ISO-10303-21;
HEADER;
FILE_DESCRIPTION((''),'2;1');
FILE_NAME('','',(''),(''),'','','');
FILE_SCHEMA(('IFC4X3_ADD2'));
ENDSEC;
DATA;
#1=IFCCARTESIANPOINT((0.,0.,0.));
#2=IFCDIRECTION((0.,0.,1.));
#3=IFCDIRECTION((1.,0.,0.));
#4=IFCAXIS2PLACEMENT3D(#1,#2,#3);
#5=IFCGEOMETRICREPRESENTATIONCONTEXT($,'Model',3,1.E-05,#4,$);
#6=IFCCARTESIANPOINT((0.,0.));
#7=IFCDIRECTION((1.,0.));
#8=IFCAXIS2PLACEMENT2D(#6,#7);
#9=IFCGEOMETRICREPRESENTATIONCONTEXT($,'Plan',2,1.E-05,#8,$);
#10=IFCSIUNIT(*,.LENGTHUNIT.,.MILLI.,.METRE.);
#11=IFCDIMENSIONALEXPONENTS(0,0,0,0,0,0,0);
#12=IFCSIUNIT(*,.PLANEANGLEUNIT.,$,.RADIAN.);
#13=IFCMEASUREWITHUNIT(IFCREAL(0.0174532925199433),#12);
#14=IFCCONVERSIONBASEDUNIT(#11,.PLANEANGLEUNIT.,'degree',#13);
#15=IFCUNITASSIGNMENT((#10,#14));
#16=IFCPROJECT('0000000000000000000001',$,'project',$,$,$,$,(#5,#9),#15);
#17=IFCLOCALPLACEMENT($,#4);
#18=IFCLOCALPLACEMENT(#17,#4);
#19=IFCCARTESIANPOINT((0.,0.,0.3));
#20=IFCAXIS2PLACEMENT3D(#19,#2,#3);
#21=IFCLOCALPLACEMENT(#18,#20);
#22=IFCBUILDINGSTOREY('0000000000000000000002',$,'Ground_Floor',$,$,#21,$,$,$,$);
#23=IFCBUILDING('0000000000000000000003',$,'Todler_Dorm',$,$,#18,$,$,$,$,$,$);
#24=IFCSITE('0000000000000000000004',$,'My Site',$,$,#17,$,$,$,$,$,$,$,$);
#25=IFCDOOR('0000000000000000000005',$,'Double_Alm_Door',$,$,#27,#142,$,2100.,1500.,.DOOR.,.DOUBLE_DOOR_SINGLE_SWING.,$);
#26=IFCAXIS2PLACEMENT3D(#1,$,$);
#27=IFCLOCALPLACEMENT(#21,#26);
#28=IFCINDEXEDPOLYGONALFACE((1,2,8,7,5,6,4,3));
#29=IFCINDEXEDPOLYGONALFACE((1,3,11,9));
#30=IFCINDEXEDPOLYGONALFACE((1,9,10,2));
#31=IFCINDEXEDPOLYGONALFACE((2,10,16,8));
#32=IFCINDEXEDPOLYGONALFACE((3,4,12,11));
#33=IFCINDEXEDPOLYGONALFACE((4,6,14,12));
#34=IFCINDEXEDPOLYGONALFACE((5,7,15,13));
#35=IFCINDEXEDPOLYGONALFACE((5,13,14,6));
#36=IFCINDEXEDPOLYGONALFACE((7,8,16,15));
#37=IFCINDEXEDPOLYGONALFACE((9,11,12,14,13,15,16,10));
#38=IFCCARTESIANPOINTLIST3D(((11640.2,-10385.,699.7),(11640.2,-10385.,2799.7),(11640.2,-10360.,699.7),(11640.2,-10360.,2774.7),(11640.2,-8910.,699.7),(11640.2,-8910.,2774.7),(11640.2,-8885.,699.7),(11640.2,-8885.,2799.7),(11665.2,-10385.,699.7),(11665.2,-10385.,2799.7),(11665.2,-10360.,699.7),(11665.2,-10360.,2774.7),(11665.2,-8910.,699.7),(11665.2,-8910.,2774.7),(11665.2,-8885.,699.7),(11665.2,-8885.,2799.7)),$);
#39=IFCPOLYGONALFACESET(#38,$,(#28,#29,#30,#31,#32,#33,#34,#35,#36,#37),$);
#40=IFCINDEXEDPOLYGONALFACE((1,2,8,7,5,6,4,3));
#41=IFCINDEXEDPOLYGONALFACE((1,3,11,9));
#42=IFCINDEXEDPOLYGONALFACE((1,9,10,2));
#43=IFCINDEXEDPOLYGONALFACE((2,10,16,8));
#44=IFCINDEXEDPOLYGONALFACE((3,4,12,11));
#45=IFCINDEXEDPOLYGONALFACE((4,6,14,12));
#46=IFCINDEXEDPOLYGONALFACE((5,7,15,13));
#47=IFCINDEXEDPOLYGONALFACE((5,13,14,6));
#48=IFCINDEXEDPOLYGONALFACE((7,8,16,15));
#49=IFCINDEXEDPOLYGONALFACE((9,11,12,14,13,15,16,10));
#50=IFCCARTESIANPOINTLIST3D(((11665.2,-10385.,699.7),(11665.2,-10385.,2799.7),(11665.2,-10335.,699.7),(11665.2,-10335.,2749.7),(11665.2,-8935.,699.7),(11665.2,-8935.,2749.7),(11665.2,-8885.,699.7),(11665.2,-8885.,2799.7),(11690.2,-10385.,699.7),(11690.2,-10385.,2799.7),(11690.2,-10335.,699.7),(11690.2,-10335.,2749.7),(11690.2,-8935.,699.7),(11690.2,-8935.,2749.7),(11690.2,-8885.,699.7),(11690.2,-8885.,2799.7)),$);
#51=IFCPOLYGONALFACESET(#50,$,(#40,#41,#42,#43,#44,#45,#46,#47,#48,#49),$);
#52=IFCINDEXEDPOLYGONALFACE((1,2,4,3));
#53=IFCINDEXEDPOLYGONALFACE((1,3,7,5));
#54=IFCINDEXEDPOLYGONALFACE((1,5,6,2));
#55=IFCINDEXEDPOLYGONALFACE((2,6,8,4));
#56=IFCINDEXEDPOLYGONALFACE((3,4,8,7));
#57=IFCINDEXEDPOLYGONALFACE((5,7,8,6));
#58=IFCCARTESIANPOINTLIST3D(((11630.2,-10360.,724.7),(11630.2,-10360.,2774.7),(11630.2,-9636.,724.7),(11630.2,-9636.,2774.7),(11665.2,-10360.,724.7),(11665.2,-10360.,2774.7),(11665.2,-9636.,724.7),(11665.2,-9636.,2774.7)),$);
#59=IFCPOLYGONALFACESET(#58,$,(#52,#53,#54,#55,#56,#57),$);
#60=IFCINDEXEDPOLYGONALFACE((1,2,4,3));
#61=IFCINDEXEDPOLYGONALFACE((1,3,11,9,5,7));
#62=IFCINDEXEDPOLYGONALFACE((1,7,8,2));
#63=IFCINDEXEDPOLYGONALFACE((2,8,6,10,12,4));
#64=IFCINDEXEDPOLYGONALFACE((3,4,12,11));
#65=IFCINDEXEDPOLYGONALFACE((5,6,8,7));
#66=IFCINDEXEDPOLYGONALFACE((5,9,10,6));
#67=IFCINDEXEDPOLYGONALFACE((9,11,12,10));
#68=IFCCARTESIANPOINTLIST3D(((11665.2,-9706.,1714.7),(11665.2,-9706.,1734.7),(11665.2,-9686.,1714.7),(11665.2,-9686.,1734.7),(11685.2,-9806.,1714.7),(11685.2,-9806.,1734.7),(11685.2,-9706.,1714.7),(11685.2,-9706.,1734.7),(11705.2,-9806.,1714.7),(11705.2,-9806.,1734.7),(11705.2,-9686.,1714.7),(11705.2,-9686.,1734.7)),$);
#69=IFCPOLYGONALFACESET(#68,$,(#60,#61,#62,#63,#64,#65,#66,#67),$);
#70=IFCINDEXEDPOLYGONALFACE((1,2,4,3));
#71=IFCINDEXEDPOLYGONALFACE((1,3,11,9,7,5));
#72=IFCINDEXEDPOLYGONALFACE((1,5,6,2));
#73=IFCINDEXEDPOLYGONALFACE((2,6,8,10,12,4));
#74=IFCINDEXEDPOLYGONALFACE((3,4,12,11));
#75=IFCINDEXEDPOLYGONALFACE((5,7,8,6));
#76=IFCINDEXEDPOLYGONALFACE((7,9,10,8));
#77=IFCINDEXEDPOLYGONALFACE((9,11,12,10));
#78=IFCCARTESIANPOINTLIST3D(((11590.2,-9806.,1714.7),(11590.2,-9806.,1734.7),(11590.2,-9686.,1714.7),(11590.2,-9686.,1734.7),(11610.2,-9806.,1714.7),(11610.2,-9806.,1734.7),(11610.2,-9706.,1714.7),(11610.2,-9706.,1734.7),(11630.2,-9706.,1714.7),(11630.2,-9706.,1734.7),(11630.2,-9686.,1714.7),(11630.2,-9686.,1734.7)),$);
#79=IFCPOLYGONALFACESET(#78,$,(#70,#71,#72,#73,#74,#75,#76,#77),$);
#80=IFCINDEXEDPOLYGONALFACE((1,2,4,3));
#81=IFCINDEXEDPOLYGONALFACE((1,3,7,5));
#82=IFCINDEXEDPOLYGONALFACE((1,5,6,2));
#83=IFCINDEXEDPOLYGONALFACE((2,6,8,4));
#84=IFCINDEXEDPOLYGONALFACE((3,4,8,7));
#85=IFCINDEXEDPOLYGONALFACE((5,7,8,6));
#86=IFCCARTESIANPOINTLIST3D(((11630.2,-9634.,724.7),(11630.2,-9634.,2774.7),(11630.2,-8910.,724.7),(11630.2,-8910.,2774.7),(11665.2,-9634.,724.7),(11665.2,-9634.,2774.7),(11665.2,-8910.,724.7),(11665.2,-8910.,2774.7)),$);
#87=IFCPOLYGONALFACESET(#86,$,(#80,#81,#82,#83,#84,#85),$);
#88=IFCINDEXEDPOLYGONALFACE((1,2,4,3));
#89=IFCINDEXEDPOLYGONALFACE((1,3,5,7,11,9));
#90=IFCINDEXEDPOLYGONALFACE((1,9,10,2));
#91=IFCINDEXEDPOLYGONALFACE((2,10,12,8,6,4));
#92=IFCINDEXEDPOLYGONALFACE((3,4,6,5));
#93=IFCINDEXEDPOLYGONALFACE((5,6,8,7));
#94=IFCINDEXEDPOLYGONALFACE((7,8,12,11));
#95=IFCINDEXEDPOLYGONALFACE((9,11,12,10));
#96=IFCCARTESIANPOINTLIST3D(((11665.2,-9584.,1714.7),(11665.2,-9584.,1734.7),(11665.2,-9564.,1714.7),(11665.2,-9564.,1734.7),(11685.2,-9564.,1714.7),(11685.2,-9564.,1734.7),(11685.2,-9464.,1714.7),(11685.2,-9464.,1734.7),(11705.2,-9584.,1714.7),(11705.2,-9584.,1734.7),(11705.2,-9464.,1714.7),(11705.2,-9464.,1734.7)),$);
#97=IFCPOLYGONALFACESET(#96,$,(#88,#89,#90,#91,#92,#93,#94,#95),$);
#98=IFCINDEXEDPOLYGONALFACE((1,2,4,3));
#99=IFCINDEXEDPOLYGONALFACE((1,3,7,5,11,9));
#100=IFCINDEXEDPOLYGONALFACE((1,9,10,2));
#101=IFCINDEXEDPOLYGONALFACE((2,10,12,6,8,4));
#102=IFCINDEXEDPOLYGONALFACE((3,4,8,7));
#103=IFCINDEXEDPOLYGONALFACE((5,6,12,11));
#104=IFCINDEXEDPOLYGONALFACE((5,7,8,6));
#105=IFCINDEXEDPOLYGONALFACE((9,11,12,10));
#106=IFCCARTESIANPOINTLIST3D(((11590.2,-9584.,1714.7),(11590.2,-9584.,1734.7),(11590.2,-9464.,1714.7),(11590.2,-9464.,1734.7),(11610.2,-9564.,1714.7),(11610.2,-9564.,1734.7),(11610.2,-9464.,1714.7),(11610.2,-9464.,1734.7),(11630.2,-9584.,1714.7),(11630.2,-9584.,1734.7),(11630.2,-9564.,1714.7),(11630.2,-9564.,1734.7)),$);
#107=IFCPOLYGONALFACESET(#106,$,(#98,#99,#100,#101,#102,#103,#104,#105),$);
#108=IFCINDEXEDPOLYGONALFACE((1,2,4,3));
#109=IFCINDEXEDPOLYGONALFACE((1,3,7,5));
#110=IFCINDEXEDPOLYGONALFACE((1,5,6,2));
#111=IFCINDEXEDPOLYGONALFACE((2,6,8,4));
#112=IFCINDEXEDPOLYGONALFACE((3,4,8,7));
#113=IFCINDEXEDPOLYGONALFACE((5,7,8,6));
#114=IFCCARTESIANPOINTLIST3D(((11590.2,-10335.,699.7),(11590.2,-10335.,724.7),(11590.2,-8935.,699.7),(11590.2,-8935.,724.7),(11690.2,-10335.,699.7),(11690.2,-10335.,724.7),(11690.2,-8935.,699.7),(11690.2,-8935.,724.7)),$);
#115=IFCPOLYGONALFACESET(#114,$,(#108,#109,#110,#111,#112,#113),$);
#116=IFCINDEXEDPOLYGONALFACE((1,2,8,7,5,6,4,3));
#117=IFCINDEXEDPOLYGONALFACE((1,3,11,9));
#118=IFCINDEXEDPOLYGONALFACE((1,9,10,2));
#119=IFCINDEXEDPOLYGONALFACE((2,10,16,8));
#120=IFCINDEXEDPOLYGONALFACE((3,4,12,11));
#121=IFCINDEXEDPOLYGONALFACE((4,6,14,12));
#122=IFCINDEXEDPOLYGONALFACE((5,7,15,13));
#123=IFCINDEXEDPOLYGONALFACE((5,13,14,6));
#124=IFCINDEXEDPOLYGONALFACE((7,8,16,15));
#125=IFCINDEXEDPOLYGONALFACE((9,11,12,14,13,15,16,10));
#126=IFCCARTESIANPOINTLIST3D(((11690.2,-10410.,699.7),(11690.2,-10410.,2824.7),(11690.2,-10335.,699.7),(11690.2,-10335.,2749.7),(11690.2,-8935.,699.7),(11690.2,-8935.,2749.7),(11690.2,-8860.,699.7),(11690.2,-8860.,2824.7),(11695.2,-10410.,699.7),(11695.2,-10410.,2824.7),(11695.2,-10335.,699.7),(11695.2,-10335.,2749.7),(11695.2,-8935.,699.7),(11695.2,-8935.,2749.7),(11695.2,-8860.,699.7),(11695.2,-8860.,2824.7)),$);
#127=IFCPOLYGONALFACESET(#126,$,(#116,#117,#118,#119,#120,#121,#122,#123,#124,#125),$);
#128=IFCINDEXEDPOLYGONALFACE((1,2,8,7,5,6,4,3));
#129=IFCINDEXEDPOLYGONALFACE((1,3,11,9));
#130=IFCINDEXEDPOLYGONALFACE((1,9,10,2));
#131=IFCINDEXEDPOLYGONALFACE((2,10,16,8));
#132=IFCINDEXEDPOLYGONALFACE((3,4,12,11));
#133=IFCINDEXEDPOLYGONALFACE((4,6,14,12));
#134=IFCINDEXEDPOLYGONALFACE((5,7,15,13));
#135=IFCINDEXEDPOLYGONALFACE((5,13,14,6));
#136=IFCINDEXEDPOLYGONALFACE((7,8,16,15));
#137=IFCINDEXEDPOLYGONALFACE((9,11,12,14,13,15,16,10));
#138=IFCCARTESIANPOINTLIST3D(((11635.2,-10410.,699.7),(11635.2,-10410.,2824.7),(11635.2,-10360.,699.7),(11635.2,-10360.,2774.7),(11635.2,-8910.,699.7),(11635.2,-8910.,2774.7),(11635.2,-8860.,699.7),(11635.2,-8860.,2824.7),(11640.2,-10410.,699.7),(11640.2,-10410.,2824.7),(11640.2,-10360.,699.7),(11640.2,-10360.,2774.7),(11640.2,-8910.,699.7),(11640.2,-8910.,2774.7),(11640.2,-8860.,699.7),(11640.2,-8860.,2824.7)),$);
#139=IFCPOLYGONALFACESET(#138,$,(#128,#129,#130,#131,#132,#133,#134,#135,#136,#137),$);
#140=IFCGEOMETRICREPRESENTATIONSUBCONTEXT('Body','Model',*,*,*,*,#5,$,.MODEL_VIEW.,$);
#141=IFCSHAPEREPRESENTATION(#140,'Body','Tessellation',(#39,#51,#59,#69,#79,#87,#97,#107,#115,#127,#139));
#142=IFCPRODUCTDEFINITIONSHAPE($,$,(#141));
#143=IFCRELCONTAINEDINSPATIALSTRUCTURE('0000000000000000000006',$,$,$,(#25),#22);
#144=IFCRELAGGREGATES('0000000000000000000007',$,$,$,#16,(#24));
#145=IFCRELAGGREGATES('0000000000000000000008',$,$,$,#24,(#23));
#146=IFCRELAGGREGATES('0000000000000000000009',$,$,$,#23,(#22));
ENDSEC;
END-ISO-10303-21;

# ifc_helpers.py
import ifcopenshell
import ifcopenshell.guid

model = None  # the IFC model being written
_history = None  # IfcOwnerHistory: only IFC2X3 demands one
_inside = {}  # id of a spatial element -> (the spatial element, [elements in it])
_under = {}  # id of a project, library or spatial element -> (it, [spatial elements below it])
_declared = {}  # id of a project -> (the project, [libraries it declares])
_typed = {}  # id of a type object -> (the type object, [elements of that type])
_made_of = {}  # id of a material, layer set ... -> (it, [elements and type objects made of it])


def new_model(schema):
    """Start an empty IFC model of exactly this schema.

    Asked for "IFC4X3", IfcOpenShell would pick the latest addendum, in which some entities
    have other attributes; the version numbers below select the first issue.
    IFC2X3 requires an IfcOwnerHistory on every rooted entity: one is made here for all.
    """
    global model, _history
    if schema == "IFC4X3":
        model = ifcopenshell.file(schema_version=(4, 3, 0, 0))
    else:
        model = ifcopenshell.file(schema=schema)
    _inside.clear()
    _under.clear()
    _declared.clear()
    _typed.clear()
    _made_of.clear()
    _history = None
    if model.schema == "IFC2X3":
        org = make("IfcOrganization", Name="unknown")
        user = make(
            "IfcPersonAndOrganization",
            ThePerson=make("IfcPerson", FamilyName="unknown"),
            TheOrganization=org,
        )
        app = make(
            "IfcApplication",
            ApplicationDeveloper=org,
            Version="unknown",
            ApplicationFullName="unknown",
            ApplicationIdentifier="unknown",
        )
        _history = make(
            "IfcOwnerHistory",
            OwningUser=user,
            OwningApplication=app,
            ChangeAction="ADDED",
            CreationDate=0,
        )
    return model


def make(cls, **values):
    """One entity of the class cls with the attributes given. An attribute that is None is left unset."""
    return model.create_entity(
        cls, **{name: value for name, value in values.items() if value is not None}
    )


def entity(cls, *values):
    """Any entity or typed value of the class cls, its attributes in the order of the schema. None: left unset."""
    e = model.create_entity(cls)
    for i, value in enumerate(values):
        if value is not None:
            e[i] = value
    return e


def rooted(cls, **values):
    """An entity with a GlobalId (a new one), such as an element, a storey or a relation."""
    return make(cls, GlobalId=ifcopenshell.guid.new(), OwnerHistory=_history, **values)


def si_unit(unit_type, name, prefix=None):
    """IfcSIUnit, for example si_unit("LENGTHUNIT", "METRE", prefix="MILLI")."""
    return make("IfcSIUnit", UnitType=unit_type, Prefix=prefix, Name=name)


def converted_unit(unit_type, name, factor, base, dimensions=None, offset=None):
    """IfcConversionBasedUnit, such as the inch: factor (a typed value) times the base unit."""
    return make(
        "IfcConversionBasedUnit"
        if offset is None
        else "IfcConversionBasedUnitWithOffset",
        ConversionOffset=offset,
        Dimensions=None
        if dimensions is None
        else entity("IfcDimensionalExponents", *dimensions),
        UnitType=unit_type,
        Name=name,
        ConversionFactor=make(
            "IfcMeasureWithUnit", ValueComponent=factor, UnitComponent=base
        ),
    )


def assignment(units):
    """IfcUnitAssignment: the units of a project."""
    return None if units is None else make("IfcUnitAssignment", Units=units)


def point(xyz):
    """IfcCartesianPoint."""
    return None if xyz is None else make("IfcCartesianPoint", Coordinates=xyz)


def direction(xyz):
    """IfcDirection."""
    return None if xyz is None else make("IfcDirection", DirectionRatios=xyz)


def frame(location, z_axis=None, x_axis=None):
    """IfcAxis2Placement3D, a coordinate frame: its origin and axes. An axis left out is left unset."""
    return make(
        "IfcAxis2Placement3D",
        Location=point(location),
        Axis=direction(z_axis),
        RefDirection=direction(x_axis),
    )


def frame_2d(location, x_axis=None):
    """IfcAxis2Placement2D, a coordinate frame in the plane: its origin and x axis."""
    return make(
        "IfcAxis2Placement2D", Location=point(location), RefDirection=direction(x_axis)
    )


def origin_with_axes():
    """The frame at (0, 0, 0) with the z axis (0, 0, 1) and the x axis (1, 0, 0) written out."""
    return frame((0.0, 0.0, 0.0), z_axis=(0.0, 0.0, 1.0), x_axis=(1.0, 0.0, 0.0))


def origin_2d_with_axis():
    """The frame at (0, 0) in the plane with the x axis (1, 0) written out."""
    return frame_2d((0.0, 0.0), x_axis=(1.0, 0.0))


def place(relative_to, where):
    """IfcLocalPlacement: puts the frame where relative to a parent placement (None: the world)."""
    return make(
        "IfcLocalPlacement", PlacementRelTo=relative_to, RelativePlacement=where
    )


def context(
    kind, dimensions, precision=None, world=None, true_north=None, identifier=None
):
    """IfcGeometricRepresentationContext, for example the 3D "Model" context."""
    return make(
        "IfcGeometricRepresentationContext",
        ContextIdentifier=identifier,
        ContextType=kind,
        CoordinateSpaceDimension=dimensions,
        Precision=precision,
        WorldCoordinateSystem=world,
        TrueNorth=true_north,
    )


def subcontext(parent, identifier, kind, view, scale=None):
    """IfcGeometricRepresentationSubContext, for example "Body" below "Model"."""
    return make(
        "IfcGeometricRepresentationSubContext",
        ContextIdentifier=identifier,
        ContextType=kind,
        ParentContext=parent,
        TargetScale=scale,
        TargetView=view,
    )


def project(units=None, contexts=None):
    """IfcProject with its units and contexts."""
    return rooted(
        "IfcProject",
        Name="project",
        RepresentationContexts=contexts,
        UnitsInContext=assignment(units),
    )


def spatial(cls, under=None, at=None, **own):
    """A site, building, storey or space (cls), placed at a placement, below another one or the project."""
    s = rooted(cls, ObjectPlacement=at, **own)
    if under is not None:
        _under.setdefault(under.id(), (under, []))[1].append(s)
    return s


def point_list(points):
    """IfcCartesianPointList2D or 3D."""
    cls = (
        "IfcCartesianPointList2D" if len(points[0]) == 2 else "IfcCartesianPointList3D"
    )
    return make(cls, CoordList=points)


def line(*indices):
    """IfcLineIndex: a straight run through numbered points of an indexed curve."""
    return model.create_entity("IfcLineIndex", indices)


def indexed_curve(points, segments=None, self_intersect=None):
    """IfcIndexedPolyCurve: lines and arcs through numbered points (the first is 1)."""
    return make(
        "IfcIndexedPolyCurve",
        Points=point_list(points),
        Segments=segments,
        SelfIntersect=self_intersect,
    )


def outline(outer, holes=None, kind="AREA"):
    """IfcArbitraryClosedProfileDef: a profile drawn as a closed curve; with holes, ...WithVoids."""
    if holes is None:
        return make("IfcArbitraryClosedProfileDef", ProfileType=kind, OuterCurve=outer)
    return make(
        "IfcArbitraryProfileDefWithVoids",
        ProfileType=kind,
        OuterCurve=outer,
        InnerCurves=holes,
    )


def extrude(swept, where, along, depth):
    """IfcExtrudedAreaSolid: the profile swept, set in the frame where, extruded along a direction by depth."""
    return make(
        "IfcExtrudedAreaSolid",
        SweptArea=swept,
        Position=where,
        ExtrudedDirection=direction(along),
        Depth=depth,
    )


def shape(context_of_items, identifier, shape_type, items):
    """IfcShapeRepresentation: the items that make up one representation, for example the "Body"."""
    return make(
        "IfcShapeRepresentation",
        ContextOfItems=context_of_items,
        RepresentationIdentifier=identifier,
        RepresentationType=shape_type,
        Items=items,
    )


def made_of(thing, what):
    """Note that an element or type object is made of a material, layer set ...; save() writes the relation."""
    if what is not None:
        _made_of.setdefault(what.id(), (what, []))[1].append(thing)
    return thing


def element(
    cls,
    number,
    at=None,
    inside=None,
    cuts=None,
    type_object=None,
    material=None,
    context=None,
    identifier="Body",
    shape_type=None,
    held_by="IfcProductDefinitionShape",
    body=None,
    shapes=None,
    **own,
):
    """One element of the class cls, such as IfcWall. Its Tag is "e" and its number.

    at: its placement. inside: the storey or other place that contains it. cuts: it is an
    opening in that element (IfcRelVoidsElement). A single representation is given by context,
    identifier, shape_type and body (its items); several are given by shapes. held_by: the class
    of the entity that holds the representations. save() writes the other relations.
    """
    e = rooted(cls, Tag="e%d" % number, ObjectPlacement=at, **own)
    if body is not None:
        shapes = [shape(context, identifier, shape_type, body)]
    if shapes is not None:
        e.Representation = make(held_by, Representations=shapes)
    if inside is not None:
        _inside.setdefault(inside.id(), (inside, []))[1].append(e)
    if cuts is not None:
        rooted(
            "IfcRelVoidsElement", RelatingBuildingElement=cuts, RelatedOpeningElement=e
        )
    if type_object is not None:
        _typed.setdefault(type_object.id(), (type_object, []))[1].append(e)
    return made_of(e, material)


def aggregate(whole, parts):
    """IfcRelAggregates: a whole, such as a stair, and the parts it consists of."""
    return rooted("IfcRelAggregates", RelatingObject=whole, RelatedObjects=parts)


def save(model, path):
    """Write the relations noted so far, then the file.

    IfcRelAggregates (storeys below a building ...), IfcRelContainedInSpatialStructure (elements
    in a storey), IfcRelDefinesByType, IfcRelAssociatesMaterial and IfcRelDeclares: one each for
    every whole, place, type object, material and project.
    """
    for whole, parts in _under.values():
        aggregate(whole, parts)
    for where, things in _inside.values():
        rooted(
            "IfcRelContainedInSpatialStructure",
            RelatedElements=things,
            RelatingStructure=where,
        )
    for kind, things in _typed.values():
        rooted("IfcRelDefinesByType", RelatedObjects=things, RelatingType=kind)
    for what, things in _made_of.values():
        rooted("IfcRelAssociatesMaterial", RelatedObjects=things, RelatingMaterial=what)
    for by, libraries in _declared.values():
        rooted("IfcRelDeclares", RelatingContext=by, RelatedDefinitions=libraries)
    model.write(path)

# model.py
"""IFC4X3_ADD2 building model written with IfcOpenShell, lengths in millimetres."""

from ifc_helpers import new_model, entity, si_unit, converted_unit, frame, origin_with_axes, origin_2d_with_axis, place, context, subcontext, project, spatial, line, indexed_curve, outline, extrude, shape, element, save


model = new_model("IFC4X3_ADD2")

# Units and contexts
model_context = context("Model", 3, precision=1e-05, world=origin_with_axes())
plan_context = context("Plan", 2, precision=1e-05, world=origin_2d_with_axis())
body_context_1 = subcontext(model_context, "Body", "Model", "MODEL_VIEW")
body_context_2 = subcontext(plan_context, "Body", "Plan", "PLAN_VIEW")
ifc_project = project(units=[si_unit("LENGTHUNIT", "METRE", prefix="MILLI"), converted_unit("PLANEANGLEUNIT", "degree", entity("IfcReal", 0.0174532925199433), si_unit("PLANEANGLEUNIT", "RADIAN"), dimensions=[0, 0, 0, 0, 0, 0, 0])], contexts=[model_context, plan_context])

# Site, building, storey
site_placement = place(None, origin_with_axes())
site = spatial("IfcSite", under=ifc_project, at=site_placement, Name="My Site")
building_placement = place(site_placement, origin_with_axes())
building = spatial("IfcBuilding", under=site, at=building_placement, Name="Todler_Dorm")
storey_placement = place(building_placement, frame((0.0, 0.0, 0.3), z_axis=(0.0, 0.0, 1.0), x_axis=(1.0, 0.0, 0.0)))
storey = spatial("IfcBuildingStorey", under=building, at=storey_placement, Name="Ground_Floor")

# Door
door_placement = place(storey_placement, frame((11690.2, -10385.0, 699.7), z_axis=(0.0, 0.0, 1.0), x_axis=(0.0, 1.0, 0.0)))
element("IfcDoor", 1, at=door_placement, inside=storey, Name="Double_Alm_Door", OperationType="DOUBLE_DOOR_SINGLE_SWING", OverallHeight=2100.0, OverallWidth=1500.0, PredefinedType="DOOR", shapes=[
    shape(body_context_1, "Body", "SweptSolid", [extrude(outline(indexed_curve([(0.0, 0.0), (0.0, 2100.0), (1500.0, 2100.0), (1500.0, 0.0), (1475.0, 0.0), (1475.0, 2075.0), (25.0, 2075.0), (25.0, 0.0)], segments=[line(1, 2, 3, 4, 5, 6, 7, 8, 1)])), frame((0.0, 25.0, 0.0), z_axis=(0.0, -1.0, 0.0), x_axis=(1.0, 0.0, 0.0)), (0.0, 0.0, -1.0), 25.0), extrude(outline(indexed_curve([(0.0, 0.0), (0.0, 2100.0), (1500.0, 2100.0), (1500.0, 0.0), (1450.0, 0.0), (1450.0, 2050.0), (50.0, 2050.0), (50.0, 0.0)], segments=[line(1, 2, 3, 4, 5, 6, 7, 8, 1)])), frame((0.0, 0.0, 0.0), z_axis=(0.0, -1.0, 0.0), x_axis=(1.0, 0.0, 0.0)), (0.0, 0.0, -1.0), 25.0), extrude(outline(indexed_curve([(0.0, 0.0), (724.0, 0.0), (724.0, 35.0), (0.0, 35.0)], segments=[line(1, 2, 3, 4, 1)])), frame((25.0, 25.0, 25.0), z_axis=(0.0, 0.0, 1.0), x_axis=(1.0, 0.0, 0.0)), (0.0, 0.0, 1.0), 2050.0), extrude(outline(indexed_curve([(0.0, 0.0), (0.0, -40.0), (-120.0, -40.0), (-120.0, -20.0), (-20.0, -20.0), (-20.0, 0.0)], segments=[line(1, 2, 3, 4, 5, 6, 1)])), frame((699.0, 25.0, 1015.0), z_axis=(0.0, 0.0, 1.0), x_axis=(1.0, 0.0, 0.0)), (0.0, 0.0, 1.0), 20.0), extrude(outline(indexed_curve([(0.0, 0.0), (0.0, 40.0), (-120.0, 40.0), (-120.0, 20.0), (-20.0, 20.0), (-20.0, 0.0)], segments=[line(1, 2, 3, 4, 5, 6, 1)])), frame((699.0, 60.0, 1015.0), z_axis=(0.0, 0.0, 1.0), x_axis=(1.0, 0.0, 0.0)), (0.0, 0.0, 1.0), 20.0), extrude(outline(indexed_curve([(0.0, 0.0), (-724.0, 0.0), (-724.0, 35.0), (0.0, 35.0)], segments=[line(1, 2, 3, 4, 1)])), frame((1475.0, 25.0, 25.0), z_axis=(0.0, 0.0, 1.0), x_axis=(1.0, 0.0, 0.0)), (0.0, 0.0, 1.0), 2050.0), extrude(outline(indexed_curve([(0.0, 0.0), (0.0, -40.0), (120.0, -40.0), (120.0, -20.0), (20.0, -20.0), (20.0, 0.0)], segments=[line(1, 2, 3, 4, 5, 6, 1)])), frame((801.0, 25.0, 1015.0), z_axis=(0.0, 0.0, 1.0), x_axis=(1.0, 0.0, 0.0)), (0.0, 0.0, 1.0), 20.0), extrude(outline(indexed_curve([(0.0, 0.0), (0.0, 40.0), (120.0, 40.0), (120.0, 20.0), (20.0, 20.0), (20.0, 0.0)], segments=[line(1, 2, 3, 4, 5, 6, 1)])), frame((801.0, 60.0, 1015.0), z_axis=(0.0, 0.0, 1.0), x_axis=(1.0, 0.0, 0.0)), (0.0, 0.0, 1.0), 20.0), extrude(outline(indexed_curve([(0.0, 0.0), (1400.0, 0.0), (1400.0, 100.0), (0.0, 100.0)], segments=[line(1, 2, 3, 4, 1)])), frame((50.0, 0.0, 0.0), z_axis=(0.0, 0.0, 1.0), x_axis=(1.0, 0.0, 0.0)), (0.0, 0.0, 1.0), 25.0), extrude(outline(indexed_curve([(0.0, 0.0), (0.0, 2125.0), (1550.0, 2125.0), (1550.0, 0.0), (1475.0, 0.0), (1475.0, 2050.0), (75.0, 2050.0), (75.0, 0.0)], segments=[line(1, 2, 3, 4, 5, 6, 7, 8, 1)])), frame((-25.0, -5.0, 0.0), z_axis=(0.0, -1.0, 0.0), x_axis=(1.0, 0.0, 0.0)), (0.0, 0.0, -1.0), 5.0), extrude(outline(indexed_curve([(0.0, 0.0), (0.0, 2125.0), (1550.0, 2125.0), (1550.0, 0.0), (1500.0, 0.0), (1500.0, 2075.0), (50.0, 2075.0), (50.0, 0.0)], segments=[line(1, 2, 3, 4, 5, 6, 7, 8, 1)])), frame((-25.0, 50.0, 0.0), z_axis=(0.0, -1.0, 0.0), x_axis=(1.0, 0.0, 0.0)), (0.0, 0.0, -1.0), 5.0)]),
    shape(body_context_2, "Body", "Curve2D", [entity("IfcIndexedPolyCurve", entity("IfcCartesianPointList2D", [[0.0, 0.0], [0.0, 50.0], [25.0, 50.0], [25.0, 25.0], [50.0, 25.0], [50.0, 0.0]]), [entity("IfcLineIndex", [1, 2, 3, 4, 5, 6, 1])]), entity("IfcIndexedPolyCurve", entity("IfcCartesianPointList2D", [[1500.0, 0.0], [1500.0, 50.0], [1475.0, 50.0], [1475.0, 25.0], [1450.0, 25.0], [1450.0, 0.0]]), [entity("IfcLineIndex", [1, 2, 3, 4, 5, 6, 1])]), entity("IfcTrimmedCurve", entity("IfcEllipse", entity("IfcAxis2Placement2D", entity("IfcCartesianPoint", [60.0, 50.0]), entity("IfcDirection", [1.0, 0.0])), 690.0, 725.0), [entity("IfcCartesianPoint", [750.0, 50.0])], [entity("IfcCartesianPoint", [60.0, 775.0])], True, "CARTESIAN"), entity("IfcIndexedPolyCurve", entity("IfcCartesianPointList2D", [[25.0, 50.0], [60.0, 50.0], [60.0, 775.0], [25.0, 775.0]]), [entity("IfcLineIndex", [1, 2, 3, 4, 1])]), entity("IfcTrimmedCurve", entity("IfcEllipse", entity("IfcAxis2Placement2D", entity("IfcCartesianPoint", [1440.0, 50.0]), entity("IfcDirection", [1.0, 0.0])), 690.0, 725.0), [entity("IfcCartesianPoint", [1440.0, 775.0])], [entity("IfcCartesianPoint", [750.0, 50.0])], True, "CARTESIAN"), entity("IfcIndexedPolyCurve", entity("IfcCartesianPointList2D", [[1475.0, 50.0], [1440.0, 50.0], [1440.0, 775.0], [1475.0, 775.0]]), [entity("IfcLineIndex", [1, 2, 3, 4, 1])])]),
])

save(model, "model.ifc")
